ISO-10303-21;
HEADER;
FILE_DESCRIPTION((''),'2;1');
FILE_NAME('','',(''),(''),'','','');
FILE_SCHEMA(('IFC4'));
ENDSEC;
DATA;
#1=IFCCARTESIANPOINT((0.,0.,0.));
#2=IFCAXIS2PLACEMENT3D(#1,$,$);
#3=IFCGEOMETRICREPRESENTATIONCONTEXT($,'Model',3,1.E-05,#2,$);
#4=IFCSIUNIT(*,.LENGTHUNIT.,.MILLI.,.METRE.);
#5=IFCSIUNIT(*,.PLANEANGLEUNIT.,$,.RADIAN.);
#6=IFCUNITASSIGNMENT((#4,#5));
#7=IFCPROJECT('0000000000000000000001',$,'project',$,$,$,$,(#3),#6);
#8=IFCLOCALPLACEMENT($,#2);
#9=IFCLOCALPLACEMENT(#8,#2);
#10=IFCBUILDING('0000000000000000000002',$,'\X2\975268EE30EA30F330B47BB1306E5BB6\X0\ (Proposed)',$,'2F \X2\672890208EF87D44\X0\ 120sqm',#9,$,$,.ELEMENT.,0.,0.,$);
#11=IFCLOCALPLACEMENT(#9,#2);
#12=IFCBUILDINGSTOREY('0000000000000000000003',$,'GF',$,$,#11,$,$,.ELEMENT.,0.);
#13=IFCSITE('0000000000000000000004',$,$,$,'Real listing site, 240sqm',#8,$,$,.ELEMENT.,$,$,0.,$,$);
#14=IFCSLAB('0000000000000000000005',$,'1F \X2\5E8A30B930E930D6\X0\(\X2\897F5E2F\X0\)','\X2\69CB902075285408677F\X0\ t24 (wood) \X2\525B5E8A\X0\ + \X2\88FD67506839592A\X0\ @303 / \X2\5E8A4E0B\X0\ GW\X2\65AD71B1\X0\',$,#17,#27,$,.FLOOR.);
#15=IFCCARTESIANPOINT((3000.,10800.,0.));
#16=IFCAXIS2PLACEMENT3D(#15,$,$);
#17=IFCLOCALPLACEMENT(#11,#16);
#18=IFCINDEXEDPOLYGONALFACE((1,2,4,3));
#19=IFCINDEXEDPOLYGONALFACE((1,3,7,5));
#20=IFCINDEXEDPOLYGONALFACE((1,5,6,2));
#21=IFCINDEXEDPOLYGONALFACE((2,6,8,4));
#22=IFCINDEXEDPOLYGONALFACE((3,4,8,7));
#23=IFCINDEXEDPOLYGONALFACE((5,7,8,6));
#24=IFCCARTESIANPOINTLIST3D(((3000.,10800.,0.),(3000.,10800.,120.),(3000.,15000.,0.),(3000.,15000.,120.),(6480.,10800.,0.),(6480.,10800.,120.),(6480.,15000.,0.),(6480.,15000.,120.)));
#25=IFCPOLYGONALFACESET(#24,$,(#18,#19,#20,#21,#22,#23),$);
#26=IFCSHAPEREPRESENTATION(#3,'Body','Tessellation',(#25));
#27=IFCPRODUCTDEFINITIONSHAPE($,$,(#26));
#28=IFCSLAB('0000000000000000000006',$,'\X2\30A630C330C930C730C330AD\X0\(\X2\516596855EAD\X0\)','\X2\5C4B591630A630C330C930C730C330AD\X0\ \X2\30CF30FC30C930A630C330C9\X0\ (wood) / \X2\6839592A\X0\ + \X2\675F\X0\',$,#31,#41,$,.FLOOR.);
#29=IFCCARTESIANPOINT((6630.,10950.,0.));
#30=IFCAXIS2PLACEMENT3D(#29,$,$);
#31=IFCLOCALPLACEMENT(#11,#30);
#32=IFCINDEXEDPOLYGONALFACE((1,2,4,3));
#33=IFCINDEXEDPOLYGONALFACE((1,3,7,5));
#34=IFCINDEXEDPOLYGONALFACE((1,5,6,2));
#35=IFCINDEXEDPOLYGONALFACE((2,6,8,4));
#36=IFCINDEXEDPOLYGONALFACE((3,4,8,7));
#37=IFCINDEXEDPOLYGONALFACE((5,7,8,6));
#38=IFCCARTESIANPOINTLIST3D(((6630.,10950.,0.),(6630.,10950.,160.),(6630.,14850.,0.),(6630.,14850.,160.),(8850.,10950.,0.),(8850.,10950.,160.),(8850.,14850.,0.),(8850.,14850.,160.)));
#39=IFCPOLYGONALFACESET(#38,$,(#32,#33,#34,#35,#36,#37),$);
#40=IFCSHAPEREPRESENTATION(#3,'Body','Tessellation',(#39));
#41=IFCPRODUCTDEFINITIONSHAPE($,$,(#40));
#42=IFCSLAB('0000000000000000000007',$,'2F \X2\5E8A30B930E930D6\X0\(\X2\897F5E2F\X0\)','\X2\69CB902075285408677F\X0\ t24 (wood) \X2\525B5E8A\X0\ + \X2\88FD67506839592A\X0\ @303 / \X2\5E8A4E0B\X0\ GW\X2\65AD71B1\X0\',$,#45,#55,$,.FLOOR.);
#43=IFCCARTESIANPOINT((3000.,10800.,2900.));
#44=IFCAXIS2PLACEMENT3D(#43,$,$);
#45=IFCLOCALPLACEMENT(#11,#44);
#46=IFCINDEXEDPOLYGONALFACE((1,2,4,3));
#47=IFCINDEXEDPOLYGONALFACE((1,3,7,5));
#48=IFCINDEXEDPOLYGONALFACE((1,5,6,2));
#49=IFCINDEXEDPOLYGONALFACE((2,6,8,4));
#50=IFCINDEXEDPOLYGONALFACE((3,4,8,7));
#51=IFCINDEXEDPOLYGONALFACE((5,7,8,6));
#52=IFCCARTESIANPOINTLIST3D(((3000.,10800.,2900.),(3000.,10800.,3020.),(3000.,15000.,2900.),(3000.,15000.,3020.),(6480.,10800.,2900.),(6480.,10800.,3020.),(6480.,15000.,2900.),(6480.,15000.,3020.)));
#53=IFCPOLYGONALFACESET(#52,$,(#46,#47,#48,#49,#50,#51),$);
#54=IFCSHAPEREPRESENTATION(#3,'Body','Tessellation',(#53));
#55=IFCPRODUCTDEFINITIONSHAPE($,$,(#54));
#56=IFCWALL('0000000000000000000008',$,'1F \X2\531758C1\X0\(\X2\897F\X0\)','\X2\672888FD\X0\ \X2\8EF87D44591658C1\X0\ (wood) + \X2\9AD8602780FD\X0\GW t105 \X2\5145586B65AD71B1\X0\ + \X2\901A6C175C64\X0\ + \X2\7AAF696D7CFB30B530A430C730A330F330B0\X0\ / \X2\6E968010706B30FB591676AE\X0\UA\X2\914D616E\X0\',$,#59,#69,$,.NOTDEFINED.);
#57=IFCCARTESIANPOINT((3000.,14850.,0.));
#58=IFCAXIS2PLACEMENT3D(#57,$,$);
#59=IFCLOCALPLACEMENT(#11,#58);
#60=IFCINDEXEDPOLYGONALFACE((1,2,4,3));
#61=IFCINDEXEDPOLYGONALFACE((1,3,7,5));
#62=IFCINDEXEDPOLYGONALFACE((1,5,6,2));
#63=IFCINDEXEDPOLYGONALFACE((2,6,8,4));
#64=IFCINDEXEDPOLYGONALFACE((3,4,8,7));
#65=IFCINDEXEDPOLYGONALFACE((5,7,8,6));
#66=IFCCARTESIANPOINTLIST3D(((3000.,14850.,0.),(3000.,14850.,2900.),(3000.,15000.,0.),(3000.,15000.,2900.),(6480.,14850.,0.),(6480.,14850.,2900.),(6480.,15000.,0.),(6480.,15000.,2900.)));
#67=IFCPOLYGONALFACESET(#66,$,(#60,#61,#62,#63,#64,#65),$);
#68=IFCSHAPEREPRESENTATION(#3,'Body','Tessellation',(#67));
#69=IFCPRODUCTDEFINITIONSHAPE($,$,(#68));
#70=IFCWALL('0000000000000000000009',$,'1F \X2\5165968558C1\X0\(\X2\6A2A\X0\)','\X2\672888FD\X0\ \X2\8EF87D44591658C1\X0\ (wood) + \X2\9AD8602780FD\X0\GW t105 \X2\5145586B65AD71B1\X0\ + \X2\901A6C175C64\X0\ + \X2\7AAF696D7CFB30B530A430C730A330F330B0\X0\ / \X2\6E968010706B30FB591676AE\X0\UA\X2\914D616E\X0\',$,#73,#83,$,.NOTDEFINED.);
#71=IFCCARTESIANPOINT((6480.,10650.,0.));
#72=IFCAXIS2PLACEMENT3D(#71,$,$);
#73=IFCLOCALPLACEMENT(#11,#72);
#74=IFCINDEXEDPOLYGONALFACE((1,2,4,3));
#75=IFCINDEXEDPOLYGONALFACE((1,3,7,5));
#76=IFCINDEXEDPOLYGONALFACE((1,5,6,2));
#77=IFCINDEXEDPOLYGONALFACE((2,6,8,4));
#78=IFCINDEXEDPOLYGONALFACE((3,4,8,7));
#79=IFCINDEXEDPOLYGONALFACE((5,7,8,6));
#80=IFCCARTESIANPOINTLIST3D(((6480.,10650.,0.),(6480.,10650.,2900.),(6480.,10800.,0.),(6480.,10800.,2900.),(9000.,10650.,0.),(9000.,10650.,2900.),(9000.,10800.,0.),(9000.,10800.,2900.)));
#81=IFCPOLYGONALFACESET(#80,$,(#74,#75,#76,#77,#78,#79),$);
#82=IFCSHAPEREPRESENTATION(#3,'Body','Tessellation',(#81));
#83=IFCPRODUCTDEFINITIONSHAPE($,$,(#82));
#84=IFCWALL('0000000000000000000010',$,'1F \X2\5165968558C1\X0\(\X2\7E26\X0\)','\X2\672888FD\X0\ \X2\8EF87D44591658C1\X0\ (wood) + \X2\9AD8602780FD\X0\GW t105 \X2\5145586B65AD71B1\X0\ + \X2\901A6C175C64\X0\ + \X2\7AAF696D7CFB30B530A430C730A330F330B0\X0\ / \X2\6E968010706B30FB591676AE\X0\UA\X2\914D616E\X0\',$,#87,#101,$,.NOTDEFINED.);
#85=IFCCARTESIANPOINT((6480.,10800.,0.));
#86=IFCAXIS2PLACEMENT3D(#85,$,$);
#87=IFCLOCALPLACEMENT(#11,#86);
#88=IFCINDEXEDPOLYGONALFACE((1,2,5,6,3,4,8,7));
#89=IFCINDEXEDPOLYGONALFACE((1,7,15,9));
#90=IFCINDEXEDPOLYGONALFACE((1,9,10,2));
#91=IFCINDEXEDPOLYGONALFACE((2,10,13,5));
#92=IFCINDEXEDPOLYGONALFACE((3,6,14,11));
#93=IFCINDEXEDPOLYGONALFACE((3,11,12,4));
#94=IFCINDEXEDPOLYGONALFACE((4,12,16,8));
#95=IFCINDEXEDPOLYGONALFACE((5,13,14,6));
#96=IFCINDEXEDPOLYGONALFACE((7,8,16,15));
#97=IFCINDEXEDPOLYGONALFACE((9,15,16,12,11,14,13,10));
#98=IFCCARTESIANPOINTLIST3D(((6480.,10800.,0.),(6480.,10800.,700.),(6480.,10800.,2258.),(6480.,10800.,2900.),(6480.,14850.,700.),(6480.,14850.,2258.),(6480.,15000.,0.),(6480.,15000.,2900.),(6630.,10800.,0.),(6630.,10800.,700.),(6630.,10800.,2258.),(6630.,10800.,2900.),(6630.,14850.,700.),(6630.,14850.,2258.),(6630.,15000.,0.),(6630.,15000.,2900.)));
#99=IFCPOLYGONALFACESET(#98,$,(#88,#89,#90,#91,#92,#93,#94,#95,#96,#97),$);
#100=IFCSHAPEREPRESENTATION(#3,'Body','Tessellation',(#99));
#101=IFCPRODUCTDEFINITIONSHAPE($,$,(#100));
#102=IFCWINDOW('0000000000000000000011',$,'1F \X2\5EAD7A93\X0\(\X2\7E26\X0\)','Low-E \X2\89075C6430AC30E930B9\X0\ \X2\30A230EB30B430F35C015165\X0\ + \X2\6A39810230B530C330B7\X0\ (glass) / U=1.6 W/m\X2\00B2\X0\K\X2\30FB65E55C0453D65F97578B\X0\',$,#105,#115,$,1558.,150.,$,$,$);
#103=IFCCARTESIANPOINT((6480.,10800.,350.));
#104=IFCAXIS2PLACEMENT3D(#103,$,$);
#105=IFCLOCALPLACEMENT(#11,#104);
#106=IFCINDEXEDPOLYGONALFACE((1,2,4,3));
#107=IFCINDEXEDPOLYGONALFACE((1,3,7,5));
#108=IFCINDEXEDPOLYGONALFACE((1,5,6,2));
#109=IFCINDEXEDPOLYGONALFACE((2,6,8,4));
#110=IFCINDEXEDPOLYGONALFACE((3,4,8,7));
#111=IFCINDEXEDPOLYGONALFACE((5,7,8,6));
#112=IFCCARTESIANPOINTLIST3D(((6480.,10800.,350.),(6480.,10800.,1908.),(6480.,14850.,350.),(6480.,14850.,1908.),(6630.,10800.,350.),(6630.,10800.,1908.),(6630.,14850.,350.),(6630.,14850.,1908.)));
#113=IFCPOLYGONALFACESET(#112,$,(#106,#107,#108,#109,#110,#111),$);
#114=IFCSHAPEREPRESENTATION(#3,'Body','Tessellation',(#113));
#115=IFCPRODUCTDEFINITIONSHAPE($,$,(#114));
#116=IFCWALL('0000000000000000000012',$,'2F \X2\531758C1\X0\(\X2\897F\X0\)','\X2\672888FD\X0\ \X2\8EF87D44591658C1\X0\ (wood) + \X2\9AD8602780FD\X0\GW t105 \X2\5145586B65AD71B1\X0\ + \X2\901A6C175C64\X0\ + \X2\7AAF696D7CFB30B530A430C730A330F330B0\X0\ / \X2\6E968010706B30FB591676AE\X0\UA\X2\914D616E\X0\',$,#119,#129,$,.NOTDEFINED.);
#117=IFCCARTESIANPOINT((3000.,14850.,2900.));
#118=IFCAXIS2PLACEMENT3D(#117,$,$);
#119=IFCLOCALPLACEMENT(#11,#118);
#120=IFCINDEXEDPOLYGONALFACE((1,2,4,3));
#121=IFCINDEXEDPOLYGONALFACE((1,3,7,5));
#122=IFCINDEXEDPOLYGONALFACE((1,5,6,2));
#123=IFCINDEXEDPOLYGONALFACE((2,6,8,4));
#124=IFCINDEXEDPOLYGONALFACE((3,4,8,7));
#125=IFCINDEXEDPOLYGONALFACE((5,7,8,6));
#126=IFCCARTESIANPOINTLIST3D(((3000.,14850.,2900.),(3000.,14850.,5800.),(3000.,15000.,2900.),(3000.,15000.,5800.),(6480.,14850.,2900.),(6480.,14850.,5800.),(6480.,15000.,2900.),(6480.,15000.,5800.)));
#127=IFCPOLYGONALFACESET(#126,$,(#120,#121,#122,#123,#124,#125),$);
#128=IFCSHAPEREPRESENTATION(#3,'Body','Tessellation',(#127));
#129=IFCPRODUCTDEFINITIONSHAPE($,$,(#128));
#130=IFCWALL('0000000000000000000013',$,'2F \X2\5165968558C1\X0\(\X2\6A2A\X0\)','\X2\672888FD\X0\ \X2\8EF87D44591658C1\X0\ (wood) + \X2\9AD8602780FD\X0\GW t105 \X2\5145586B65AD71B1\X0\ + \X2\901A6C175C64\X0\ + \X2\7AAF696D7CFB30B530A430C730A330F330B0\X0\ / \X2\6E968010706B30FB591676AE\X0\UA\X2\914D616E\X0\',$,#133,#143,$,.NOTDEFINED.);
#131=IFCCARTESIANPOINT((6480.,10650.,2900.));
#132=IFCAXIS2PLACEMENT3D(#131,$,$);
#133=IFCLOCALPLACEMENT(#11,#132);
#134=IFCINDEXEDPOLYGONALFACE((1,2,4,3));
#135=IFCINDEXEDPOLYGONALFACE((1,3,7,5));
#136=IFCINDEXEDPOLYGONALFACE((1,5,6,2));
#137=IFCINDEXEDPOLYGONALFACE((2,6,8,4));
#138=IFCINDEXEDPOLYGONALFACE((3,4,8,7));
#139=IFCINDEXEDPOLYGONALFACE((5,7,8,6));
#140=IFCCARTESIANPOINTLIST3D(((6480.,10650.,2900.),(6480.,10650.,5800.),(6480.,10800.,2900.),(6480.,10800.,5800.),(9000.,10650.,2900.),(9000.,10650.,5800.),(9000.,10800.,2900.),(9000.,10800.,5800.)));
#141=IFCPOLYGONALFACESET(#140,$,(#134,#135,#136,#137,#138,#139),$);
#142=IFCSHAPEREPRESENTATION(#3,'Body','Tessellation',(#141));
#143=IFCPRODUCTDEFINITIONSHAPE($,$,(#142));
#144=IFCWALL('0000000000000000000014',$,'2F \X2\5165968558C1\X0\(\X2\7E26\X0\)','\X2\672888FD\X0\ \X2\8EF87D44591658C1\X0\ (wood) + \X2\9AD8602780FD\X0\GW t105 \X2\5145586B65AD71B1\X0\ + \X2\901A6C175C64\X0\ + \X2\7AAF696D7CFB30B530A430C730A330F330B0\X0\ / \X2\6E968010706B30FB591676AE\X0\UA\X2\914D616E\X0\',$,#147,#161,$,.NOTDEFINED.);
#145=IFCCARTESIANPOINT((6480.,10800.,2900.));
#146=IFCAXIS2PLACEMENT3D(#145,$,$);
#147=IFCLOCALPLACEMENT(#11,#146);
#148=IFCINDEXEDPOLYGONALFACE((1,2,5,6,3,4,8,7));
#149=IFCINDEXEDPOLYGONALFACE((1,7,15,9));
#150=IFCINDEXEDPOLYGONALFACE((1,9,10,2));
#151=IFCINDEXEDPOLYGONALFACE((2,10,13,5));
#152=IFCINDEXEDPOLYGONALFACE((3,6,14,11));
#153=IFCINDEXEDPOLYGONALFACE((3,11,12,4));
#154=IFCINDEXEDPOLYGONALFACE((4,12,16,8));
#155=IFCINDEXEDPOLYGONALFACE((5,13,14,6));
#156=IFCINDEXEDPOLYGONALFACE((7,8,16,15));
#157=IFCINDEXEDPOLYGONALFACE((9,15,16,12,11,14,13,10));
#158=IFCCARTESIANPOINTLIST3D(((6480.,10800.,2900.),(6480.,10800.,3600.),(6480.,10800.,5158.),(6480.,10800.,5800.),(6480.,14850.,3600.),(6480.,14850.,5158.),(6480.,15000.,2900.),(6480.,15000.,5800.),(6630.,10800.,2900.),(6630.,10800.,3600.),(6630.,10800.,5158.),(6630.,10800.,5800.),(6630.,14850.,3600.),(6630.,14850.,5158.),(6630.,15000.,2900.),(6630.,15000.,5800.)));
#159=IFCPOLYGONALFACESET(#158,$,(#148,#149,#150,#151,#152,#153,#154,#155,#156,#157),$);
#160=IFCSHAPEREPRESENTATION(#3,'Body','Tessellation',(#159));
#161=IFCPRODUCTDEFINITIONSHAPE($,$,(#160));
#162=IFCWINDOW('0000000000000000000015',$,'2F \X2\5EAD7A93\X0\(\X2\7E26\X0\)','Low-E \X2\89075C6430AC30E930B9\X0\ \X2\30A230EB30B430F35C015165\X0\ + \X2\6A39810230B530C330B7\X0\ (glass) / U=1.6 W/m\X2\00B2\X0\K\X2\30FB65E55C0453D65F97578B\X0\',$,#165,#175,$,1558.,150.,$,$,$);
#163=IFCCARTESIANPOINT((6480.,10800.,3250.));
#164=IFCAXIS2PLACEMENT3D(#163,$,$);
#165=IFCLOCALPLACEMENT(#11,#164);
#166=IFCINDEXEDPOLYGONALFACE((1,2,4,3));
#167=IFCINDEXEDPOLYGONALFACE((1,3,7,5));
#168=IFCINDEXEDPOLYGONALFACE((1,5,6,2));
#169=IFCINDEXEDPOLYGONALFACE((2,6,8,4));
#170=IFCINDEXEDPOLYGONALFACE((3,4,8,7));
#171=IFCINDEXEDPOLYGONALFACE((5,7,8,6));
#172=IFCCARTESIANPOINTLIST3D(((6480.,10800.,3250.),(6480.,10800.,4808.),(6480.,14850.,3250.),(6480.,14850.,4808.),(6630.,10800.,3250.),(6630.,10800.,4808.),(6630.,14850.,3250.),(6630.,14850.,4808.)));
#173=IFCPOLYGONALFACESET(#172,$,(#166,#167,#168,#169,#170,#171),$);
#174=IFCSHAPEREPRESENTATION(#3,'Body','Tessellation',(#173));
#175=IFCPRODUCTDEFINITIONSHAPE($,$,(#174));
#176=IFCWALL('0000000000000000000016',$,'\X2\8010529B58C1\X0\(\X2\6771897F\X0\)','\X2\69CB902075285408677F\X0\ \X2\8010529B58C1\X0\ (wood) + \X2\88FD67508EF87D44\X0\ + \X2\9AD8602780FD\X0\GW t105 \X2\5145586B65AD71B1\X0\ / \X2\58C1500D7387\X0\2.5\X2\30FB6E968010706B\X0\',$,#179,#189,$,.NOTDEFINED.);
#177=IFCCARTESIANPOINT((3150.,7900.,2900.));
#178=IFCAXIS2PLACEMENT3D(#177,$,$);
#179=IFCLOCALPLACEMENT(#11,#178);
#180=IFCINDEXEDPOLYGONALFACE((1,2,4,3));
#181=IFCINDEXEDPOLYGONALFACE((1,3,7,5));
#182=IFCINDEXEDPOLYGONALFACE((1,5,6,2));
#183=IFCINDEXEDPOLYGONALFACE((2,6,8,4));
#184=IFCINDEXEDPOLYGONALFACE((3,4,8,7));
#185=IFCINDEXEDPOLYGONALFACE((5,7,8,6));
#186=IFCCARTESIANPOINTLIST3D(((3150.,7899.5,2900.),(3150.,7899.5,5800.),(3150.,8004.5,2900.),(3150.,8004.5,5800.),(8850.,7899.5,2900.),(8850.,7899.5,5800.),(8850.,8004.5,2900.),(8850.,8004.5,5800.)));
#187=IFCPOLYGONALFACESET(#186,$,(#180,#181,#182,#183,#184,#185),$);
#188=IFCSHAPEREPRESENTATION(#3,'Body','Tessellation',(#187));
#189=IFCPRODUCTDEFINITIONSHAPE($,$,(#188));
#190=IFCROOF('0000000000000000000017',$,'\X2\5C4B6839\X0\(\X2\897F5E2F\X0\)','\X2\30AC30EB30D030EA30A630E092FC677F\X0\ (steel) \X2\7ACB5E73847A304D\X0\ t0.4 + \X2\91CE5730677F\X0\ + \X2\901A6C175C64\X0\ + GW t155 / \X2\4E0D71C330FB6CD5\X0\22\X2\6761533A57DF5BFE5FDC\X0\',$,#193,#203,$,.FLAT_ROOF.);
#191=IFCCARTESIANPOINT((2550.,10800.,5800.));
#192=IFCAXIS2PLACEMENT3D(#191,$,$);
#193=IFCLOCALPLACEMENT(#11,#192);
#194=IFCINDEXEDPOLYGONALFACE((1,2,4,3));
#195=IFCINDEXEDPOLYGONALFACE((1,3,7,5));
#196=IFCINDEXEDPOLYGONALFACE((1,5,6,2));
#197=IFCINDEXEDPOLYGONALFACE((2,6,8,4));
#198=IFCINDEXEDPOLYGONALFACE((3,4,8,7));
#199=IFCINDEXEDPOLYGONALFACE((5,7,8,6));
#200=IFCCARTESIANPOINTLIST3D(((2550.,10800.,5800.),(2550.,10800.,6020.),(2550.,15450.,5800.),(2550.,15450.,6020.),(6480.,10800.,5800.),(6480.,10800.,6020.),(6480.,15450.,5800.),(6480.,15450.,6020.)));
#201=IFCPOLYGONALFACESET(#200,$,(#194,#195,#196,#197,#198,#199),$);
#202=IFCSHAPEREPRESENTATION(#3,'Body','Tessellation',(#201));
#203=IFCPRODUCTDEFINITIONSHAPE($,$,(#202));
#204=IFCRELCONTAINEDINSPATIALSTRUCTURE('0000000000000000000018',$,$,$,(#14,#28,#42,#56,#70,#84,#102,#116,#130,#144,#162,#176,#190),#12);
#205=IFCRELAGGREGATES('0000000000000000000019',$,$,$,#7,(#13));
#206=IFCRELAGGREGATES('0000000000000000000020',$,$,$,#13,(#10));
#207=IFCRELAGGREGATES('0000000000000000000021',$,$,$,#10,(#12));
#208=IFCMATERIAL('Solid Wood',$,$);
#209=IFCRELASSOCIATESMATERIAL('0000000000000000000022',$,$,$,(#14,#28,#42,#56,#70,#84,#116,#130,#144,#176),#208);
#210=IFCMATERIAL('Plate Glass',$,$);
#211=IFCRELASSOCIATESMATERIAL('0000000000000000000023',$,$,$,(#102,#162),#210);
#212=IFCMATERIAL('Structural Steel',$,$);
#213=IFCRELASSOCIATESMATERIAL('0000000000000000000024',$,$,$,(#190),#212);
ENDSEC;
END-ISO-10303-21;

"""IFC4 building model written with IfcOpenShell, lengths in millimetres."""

from ifc_helpers import new_model, si_unit, frame, frame_2d, origin, place, context, project, spatial, rectangle, extrude, material, element, fill, save


model = new_model("IFC4")

# Units and contexts
model_context = context("Model", 3, precision=1e-05, world=origin())
ifc_project = project(units=[si_unit("LENGTHUNIT", "METRE", prefix="MILLI"), si_unit("PLANEANGLEUNIT", "RADIAN")], contexts=[model_context])

# Site, building, storey
site_placement = place(None, origin())
site = spatial("IfcSite", under=ifc_project, at=site_placement, ObjectType="Real listing site, 240sqm", CompositionType="ELEMENT", RefElevation=0.0)
building_placement = place(site_placement, origin())
building = spatial("IfcBuilding", under=site, at=building_placement, Name="青森リンゴ箱の家 (Proposed)", ObjectType="2F 木造軸組 120sqm", CompositionType="ELEMENT", ElevationOfRefHeight=0.0, ElevationOfTerrain=0.0)
storey_placement = place(building_placement, origin())
storey = spatial("IfcBuildingStorey", under=building, at=storey_placement, Name="GF", CompositionType="ELEMENT", Elevation=0.0)

# Slabs
ifc_material_1 = material(Name="Solid Wood")
slab_1_placement = place(storey_placement, frame((3000.0, 10800.0, 0.0)))
element("IfcSlab", 1, at=slab_1_placement, inside=storey, material=ifc_material_1, Name="1F 床スラブ(西帯)", Description="構造用合板 t24 (wood) 剛床 + 製材根太 @303 / 床下 GW断熱", PredefinedType="FLOOR", context=model_context, shape_type="SweptSolid", body=[
    extrude(rectangle(XDim=3480.0, YDim=4200.0, at=frame_2d((1740.0, 2100.0))), frame((3000.0, 10800.0, 0.0)), (0.0, 0.0, 1.0), 120.0),
])
slab_2_placement = place(storey_placement, frame((6630.0, 10950.0, 0.0)))
element("IfcSlab", 2, at=slab_2_placement, inside=storey, material=ifc_material_1, Name="ウッドデッキ(入隅庭)", Description="屋外ウッドデッキ ハードウッド (wood) / 根太 + 束", PredefinedType="FLOOR", context=model_context, shape_type="SweptSolid", body=[
    extrude(rectangle(XDim=2220.0, YDim=3900.0, at=frame_2d((1110.0, 1950.0))), frame((6630.0, 10950.0, 0.0)), (0.0, 0.0, 1.0), 160.0),
])
slab_3_placement = place(storey_placement, frame((3000.0, 10800.0, 2900.0)))
element("IfcSlab", 3, at=slab_3_placement, inside=storey, material=ifc_material_1, Name="2F 床スラブ(西帯)", Description="構造用合板 t24 (wood) 剛床 + 製材根太 @303 / 床下 GW断熱", PredefinedType="FLOOR", context=model_context, shape_type="SweptSolid", body=[
    extrude(rectangle(XDim=3480.0, YDim=4200.0, at=frame_2d((1740.0, 2100.0))), frame((3000.0, 10800.0, 2900.0)), (0.0, 0.0, 1.0), 120.0),
])

# Walls
wall_1_placement = place(storey_placement, frame((3000.0, 14850.0, 0.0)))
element("IfcWall", 4, at=wall_1_placement, inside=storey, material=ifc_material_1, Name="1F 北壁(西)", Description="木製 軸組外壁 (wood) + 高性能GW t105 充填断熱 + 通気層 + 窯業系サイディング / 準耐火・外皮UA配慮", PredefinedType="NOTDEFINED", context=model_context, shape_type="SweptSolid", body=[
    extrude(rectangle(XDim=3480.0, YDim=150.0, at=frame_2d((1740.0, 75.0))), frame((3000.0, 14850.0, 0.0)), (0.0, 0.0, 1.0), 2900.0),
])
wall_2_placement = place(storey_placement, frame((6480.0, 10650.0, 0.0)))
element("IfcWall", 5, at=wall_2_placement, inside=storey, material=ifc_material_1, Name="1F 入隅壁(横)", Description="木製 軸組外壁 (wood) + 高性能GW t105 充填断熱 + 通気層 + 窯業系サイディング / 準耐火・外皮UA配慮", PredefinedType="NOTDEFINED", context=model_context, shape_type="SweptSolid", body=[
    extrude(rectangle(XDim=2520.0, YDim=150.0, at=frame_2d((1260.0, 75.0))), frame((6480.0, 10650.0, 0.0)), (0.0, 0.0, 1.0), 2900.0),
])

# Wall, opening, window
wall_3_placement = place(storey_placement, frame((6480.0, 10800.0, 0.0)))
wall_3 = element("IfcWall", 6, at=wall_3_placement, inside=storey, material=ifc_material_1, Name="1F 入隅壁(縦)", Description="木製 軸組外壁 (wood) + 高性能GW t105 充填断熱 + 通気層 + 窯業系サイディング / 準耐火・外皮UA配慮", PredefinedType="NOTDEFINED", context=model_context, shape_type="SweptSolid", body=[
    extrude(rectangle(XDim=150.0, YDim=4200.0, at=frame_2d((75.0, 2100.0))), frame((6480.0, 10800.0, 0.0)), (0.0, 0.0, 1.0), 2900.0),
])
opening_1_placement = place(storey_placement, frame((6480.0, 10800.0, 350.0)))
opening_1 = element("IfcOpeningElement", 7, at=opening_1_placement, cuts=wall_3, PredefinedType="NOTDEFINED", context=model_context, shape_type="SweptSolid", body=[
    extrude(rectangle(XDim=150.0, YDim=4050.0, at=frame_2d((75.0, 2025.0))), frame((6480.0, 10800.0, 350.0)), (0.0, 0.0, 1.0), 1558.0),
])
ifc_material_2 = material(Name="Plate Glass")
window_1_placement = place(storey_placement, frame((6480.0, 10800.0, 350.0)))
window_1 = element("IfcWindow", 8, at=window_1_placement, inside=storey, material=ifc_material_2, Name="1F 庭窓(縦)", Description="Low-E 複層ガラス アルゴン封入 + 樹脂サッシ (glass) / U=1.6 W/m²K・日射取得型", OverallHeight=1558.0, OverallWidth=150.0, context=model_context, shape_type="SweptSolid", body=[
    extrude(rectangle(XDim=150.0, YDim=4050.0, at=frame_2d((75.0, 2025.0))), frame((6480.0, 10800.0, 350.0)), (0.0, 0.0, 1.0), 1558.0),
])
fill(opening_1, window_1)

# Walls
wall_4_placement = place(storey_placement, frame((3000.0, 14850.0, 2900.0)))
element("IfcWall", 9, at=wall_4_placement, inside=storey, material=ifc_material_1, Name="2F 北壁(西)", Description="木製 軸組外壁 (wood) + 高性能GW t105 充填断熱 + 通気層 + 窯業系サイディング / 準耐火・外皮UA配慮", PredefinedType="NOTDEFINED", context=model_context, shape_type="SweptSolid", body=[
    extrude(rectangle(XDim=3480.0, YDim=150.0, at=frame_2d((1740.0, 75.0))), frame((3000.0, 14850.0, 2900.0)), (0.0, 0.0, 1.0), 2900.0),
])
wall_5_placement = place(storey_placement, frame((6480.0, 10650.0, 2900.0)))
element("IfcWall", 10, at=wall_5_placement, inside=storey, material=ifc_material_1, Name="2F 入隅壁(横)", Description="木製 軸組外壁 (wood) + 高性能GW t105 充填断熱 + 通気層 + 窯業系サイディング / 準耐火・外皮UA配慮", PredefinedType="NOTDEFINED", context=model_context, shape_type="SweptSolid", body=[
    extrude(rectangle(XDim=2520.0, YDim=150.0, at=frame_2d((1260.0, 75.0))), frame((6480.0, 10650.0, 2900.0)), (0.0, 0.0, 1.0), 2900.0),
])

# Wall, opening, window
wall_6_placement = place(storey_placement, frame((6480.0, 10800.0, 2900.0)))
wall_6 = element("IfcWall", 11, at=wall_6_placement, inside=storey, material=ifc_material_1, Name="2F 入隅壁(縦)", Description="木製 軸組外壁 (wood) + 高性能GW t105 充填断熱 + 通気層 + 窯業系サイディング / 準耐火・外皮UA配慮", PredefinedType="NOTDEFINED", context=model_context, shape_type="SweptSolid", body=[
    extrude(rectangle(XDim=150.0, YDim=4200.0, at=frame_2d((75.0, 2100.0))), frame((6480.0, 10800.0, 2900.0)), (0.0, 0.0, 1.0), 2900.0),
])
opening_2_placement = place(storey_placement, frame((6480.0, 10800.0, 3250.0)))
opening_2 = element("IfcOpeningElement", 12, at=opening_2_placement, cuts=wall_6, PredefinedType="NOTDEFINED", context=model_context, shape_type="SweptSolid", body=[
    extrude(rectangle(XDim=150.0, YDim=4050.0, at=frame_2d((75.0, 2025.0))), frame((6480.0, 10800.0, 3250.0)), (0.0, 0.0, 1.0), 1558.0),
])
window_2_placement = place(storey_placement, frame((6480.0, 10800.0, 3250.0)))
window_2 = element("IfcWindow", 13, at=window_2_placement, inside=storey, material=ifc_material_2, Name="2F 庭窓(縦)", Description="Low-E 複層ガラス アルゴン封入 + 樹脂サッシ (glass) / U=1.6 W/m²K・日射取得型", OverallHeight=1558.0, OverallWidth=150.0, context=model_context, shape_type="SweptSolid", body=[
    extrude(rectangle(XDim=150.0, YDim=4050.0, at=frame_2d((75.0, 2025.0))), frame((6480.0, 10800.0, 3250.0)), (0.0, 0.0, 1.0), 1558.0),
])
fill(opening_2, window_2)

# Wall
wall_7_placement = place(storey_placement, frame((3150.0, 7900.0, 2900.0)))
element("IfcWall", 14, at=wall_7_placement, inside=storey, material=ifc_material_1, Name="耐力壁(東西)", Description="構造用合板 耐力壁 (wood) + 製材軸組 + 高性能GW t105 充填断熱 / 壁倍率2.5・準耐火", PredefinedType="NOTDEFINED", context=model_context, shape_type="SweptSolid", body=[
    extrude(rectangle(XDim=5700.0, YDim=105.0, at=frame_2d((2850.0, 52.0))), frame((3150.0, 7900.0, 2900.0)), (0.0, 0.0, 1.0), 2900.0),
])

# Roof
ifc_material_3 = material(Name="Structural Steel")
for number, where, name in (
    (15, (2550.0, 10800.0, 5800.0), "屋根(西帯)"),
):
    element("IfcRoof", number, at=place(storey_placement, frame(where)), inside=storey, material=ifc_material_3, Name=name, Description="ガルバリウム鋼板 (steel) 立平葺き t0.4 + 野地板 + 通気層 + GW t155 / 不燃・法22条区域対応", PredefinedType="FLAT_ROOF", context=model_context, shape_type="SweptSolid", body=[
        extrude(rectangle(XDim=3930.0, YDim=4650.0, at=frame_2d((1965.0, 2325.0))), frame((2550.0, 10800.0, 5800.0)), (0.0, 0.0, 1.0), 220.0),
    ])

save(model, "model.ifc")
